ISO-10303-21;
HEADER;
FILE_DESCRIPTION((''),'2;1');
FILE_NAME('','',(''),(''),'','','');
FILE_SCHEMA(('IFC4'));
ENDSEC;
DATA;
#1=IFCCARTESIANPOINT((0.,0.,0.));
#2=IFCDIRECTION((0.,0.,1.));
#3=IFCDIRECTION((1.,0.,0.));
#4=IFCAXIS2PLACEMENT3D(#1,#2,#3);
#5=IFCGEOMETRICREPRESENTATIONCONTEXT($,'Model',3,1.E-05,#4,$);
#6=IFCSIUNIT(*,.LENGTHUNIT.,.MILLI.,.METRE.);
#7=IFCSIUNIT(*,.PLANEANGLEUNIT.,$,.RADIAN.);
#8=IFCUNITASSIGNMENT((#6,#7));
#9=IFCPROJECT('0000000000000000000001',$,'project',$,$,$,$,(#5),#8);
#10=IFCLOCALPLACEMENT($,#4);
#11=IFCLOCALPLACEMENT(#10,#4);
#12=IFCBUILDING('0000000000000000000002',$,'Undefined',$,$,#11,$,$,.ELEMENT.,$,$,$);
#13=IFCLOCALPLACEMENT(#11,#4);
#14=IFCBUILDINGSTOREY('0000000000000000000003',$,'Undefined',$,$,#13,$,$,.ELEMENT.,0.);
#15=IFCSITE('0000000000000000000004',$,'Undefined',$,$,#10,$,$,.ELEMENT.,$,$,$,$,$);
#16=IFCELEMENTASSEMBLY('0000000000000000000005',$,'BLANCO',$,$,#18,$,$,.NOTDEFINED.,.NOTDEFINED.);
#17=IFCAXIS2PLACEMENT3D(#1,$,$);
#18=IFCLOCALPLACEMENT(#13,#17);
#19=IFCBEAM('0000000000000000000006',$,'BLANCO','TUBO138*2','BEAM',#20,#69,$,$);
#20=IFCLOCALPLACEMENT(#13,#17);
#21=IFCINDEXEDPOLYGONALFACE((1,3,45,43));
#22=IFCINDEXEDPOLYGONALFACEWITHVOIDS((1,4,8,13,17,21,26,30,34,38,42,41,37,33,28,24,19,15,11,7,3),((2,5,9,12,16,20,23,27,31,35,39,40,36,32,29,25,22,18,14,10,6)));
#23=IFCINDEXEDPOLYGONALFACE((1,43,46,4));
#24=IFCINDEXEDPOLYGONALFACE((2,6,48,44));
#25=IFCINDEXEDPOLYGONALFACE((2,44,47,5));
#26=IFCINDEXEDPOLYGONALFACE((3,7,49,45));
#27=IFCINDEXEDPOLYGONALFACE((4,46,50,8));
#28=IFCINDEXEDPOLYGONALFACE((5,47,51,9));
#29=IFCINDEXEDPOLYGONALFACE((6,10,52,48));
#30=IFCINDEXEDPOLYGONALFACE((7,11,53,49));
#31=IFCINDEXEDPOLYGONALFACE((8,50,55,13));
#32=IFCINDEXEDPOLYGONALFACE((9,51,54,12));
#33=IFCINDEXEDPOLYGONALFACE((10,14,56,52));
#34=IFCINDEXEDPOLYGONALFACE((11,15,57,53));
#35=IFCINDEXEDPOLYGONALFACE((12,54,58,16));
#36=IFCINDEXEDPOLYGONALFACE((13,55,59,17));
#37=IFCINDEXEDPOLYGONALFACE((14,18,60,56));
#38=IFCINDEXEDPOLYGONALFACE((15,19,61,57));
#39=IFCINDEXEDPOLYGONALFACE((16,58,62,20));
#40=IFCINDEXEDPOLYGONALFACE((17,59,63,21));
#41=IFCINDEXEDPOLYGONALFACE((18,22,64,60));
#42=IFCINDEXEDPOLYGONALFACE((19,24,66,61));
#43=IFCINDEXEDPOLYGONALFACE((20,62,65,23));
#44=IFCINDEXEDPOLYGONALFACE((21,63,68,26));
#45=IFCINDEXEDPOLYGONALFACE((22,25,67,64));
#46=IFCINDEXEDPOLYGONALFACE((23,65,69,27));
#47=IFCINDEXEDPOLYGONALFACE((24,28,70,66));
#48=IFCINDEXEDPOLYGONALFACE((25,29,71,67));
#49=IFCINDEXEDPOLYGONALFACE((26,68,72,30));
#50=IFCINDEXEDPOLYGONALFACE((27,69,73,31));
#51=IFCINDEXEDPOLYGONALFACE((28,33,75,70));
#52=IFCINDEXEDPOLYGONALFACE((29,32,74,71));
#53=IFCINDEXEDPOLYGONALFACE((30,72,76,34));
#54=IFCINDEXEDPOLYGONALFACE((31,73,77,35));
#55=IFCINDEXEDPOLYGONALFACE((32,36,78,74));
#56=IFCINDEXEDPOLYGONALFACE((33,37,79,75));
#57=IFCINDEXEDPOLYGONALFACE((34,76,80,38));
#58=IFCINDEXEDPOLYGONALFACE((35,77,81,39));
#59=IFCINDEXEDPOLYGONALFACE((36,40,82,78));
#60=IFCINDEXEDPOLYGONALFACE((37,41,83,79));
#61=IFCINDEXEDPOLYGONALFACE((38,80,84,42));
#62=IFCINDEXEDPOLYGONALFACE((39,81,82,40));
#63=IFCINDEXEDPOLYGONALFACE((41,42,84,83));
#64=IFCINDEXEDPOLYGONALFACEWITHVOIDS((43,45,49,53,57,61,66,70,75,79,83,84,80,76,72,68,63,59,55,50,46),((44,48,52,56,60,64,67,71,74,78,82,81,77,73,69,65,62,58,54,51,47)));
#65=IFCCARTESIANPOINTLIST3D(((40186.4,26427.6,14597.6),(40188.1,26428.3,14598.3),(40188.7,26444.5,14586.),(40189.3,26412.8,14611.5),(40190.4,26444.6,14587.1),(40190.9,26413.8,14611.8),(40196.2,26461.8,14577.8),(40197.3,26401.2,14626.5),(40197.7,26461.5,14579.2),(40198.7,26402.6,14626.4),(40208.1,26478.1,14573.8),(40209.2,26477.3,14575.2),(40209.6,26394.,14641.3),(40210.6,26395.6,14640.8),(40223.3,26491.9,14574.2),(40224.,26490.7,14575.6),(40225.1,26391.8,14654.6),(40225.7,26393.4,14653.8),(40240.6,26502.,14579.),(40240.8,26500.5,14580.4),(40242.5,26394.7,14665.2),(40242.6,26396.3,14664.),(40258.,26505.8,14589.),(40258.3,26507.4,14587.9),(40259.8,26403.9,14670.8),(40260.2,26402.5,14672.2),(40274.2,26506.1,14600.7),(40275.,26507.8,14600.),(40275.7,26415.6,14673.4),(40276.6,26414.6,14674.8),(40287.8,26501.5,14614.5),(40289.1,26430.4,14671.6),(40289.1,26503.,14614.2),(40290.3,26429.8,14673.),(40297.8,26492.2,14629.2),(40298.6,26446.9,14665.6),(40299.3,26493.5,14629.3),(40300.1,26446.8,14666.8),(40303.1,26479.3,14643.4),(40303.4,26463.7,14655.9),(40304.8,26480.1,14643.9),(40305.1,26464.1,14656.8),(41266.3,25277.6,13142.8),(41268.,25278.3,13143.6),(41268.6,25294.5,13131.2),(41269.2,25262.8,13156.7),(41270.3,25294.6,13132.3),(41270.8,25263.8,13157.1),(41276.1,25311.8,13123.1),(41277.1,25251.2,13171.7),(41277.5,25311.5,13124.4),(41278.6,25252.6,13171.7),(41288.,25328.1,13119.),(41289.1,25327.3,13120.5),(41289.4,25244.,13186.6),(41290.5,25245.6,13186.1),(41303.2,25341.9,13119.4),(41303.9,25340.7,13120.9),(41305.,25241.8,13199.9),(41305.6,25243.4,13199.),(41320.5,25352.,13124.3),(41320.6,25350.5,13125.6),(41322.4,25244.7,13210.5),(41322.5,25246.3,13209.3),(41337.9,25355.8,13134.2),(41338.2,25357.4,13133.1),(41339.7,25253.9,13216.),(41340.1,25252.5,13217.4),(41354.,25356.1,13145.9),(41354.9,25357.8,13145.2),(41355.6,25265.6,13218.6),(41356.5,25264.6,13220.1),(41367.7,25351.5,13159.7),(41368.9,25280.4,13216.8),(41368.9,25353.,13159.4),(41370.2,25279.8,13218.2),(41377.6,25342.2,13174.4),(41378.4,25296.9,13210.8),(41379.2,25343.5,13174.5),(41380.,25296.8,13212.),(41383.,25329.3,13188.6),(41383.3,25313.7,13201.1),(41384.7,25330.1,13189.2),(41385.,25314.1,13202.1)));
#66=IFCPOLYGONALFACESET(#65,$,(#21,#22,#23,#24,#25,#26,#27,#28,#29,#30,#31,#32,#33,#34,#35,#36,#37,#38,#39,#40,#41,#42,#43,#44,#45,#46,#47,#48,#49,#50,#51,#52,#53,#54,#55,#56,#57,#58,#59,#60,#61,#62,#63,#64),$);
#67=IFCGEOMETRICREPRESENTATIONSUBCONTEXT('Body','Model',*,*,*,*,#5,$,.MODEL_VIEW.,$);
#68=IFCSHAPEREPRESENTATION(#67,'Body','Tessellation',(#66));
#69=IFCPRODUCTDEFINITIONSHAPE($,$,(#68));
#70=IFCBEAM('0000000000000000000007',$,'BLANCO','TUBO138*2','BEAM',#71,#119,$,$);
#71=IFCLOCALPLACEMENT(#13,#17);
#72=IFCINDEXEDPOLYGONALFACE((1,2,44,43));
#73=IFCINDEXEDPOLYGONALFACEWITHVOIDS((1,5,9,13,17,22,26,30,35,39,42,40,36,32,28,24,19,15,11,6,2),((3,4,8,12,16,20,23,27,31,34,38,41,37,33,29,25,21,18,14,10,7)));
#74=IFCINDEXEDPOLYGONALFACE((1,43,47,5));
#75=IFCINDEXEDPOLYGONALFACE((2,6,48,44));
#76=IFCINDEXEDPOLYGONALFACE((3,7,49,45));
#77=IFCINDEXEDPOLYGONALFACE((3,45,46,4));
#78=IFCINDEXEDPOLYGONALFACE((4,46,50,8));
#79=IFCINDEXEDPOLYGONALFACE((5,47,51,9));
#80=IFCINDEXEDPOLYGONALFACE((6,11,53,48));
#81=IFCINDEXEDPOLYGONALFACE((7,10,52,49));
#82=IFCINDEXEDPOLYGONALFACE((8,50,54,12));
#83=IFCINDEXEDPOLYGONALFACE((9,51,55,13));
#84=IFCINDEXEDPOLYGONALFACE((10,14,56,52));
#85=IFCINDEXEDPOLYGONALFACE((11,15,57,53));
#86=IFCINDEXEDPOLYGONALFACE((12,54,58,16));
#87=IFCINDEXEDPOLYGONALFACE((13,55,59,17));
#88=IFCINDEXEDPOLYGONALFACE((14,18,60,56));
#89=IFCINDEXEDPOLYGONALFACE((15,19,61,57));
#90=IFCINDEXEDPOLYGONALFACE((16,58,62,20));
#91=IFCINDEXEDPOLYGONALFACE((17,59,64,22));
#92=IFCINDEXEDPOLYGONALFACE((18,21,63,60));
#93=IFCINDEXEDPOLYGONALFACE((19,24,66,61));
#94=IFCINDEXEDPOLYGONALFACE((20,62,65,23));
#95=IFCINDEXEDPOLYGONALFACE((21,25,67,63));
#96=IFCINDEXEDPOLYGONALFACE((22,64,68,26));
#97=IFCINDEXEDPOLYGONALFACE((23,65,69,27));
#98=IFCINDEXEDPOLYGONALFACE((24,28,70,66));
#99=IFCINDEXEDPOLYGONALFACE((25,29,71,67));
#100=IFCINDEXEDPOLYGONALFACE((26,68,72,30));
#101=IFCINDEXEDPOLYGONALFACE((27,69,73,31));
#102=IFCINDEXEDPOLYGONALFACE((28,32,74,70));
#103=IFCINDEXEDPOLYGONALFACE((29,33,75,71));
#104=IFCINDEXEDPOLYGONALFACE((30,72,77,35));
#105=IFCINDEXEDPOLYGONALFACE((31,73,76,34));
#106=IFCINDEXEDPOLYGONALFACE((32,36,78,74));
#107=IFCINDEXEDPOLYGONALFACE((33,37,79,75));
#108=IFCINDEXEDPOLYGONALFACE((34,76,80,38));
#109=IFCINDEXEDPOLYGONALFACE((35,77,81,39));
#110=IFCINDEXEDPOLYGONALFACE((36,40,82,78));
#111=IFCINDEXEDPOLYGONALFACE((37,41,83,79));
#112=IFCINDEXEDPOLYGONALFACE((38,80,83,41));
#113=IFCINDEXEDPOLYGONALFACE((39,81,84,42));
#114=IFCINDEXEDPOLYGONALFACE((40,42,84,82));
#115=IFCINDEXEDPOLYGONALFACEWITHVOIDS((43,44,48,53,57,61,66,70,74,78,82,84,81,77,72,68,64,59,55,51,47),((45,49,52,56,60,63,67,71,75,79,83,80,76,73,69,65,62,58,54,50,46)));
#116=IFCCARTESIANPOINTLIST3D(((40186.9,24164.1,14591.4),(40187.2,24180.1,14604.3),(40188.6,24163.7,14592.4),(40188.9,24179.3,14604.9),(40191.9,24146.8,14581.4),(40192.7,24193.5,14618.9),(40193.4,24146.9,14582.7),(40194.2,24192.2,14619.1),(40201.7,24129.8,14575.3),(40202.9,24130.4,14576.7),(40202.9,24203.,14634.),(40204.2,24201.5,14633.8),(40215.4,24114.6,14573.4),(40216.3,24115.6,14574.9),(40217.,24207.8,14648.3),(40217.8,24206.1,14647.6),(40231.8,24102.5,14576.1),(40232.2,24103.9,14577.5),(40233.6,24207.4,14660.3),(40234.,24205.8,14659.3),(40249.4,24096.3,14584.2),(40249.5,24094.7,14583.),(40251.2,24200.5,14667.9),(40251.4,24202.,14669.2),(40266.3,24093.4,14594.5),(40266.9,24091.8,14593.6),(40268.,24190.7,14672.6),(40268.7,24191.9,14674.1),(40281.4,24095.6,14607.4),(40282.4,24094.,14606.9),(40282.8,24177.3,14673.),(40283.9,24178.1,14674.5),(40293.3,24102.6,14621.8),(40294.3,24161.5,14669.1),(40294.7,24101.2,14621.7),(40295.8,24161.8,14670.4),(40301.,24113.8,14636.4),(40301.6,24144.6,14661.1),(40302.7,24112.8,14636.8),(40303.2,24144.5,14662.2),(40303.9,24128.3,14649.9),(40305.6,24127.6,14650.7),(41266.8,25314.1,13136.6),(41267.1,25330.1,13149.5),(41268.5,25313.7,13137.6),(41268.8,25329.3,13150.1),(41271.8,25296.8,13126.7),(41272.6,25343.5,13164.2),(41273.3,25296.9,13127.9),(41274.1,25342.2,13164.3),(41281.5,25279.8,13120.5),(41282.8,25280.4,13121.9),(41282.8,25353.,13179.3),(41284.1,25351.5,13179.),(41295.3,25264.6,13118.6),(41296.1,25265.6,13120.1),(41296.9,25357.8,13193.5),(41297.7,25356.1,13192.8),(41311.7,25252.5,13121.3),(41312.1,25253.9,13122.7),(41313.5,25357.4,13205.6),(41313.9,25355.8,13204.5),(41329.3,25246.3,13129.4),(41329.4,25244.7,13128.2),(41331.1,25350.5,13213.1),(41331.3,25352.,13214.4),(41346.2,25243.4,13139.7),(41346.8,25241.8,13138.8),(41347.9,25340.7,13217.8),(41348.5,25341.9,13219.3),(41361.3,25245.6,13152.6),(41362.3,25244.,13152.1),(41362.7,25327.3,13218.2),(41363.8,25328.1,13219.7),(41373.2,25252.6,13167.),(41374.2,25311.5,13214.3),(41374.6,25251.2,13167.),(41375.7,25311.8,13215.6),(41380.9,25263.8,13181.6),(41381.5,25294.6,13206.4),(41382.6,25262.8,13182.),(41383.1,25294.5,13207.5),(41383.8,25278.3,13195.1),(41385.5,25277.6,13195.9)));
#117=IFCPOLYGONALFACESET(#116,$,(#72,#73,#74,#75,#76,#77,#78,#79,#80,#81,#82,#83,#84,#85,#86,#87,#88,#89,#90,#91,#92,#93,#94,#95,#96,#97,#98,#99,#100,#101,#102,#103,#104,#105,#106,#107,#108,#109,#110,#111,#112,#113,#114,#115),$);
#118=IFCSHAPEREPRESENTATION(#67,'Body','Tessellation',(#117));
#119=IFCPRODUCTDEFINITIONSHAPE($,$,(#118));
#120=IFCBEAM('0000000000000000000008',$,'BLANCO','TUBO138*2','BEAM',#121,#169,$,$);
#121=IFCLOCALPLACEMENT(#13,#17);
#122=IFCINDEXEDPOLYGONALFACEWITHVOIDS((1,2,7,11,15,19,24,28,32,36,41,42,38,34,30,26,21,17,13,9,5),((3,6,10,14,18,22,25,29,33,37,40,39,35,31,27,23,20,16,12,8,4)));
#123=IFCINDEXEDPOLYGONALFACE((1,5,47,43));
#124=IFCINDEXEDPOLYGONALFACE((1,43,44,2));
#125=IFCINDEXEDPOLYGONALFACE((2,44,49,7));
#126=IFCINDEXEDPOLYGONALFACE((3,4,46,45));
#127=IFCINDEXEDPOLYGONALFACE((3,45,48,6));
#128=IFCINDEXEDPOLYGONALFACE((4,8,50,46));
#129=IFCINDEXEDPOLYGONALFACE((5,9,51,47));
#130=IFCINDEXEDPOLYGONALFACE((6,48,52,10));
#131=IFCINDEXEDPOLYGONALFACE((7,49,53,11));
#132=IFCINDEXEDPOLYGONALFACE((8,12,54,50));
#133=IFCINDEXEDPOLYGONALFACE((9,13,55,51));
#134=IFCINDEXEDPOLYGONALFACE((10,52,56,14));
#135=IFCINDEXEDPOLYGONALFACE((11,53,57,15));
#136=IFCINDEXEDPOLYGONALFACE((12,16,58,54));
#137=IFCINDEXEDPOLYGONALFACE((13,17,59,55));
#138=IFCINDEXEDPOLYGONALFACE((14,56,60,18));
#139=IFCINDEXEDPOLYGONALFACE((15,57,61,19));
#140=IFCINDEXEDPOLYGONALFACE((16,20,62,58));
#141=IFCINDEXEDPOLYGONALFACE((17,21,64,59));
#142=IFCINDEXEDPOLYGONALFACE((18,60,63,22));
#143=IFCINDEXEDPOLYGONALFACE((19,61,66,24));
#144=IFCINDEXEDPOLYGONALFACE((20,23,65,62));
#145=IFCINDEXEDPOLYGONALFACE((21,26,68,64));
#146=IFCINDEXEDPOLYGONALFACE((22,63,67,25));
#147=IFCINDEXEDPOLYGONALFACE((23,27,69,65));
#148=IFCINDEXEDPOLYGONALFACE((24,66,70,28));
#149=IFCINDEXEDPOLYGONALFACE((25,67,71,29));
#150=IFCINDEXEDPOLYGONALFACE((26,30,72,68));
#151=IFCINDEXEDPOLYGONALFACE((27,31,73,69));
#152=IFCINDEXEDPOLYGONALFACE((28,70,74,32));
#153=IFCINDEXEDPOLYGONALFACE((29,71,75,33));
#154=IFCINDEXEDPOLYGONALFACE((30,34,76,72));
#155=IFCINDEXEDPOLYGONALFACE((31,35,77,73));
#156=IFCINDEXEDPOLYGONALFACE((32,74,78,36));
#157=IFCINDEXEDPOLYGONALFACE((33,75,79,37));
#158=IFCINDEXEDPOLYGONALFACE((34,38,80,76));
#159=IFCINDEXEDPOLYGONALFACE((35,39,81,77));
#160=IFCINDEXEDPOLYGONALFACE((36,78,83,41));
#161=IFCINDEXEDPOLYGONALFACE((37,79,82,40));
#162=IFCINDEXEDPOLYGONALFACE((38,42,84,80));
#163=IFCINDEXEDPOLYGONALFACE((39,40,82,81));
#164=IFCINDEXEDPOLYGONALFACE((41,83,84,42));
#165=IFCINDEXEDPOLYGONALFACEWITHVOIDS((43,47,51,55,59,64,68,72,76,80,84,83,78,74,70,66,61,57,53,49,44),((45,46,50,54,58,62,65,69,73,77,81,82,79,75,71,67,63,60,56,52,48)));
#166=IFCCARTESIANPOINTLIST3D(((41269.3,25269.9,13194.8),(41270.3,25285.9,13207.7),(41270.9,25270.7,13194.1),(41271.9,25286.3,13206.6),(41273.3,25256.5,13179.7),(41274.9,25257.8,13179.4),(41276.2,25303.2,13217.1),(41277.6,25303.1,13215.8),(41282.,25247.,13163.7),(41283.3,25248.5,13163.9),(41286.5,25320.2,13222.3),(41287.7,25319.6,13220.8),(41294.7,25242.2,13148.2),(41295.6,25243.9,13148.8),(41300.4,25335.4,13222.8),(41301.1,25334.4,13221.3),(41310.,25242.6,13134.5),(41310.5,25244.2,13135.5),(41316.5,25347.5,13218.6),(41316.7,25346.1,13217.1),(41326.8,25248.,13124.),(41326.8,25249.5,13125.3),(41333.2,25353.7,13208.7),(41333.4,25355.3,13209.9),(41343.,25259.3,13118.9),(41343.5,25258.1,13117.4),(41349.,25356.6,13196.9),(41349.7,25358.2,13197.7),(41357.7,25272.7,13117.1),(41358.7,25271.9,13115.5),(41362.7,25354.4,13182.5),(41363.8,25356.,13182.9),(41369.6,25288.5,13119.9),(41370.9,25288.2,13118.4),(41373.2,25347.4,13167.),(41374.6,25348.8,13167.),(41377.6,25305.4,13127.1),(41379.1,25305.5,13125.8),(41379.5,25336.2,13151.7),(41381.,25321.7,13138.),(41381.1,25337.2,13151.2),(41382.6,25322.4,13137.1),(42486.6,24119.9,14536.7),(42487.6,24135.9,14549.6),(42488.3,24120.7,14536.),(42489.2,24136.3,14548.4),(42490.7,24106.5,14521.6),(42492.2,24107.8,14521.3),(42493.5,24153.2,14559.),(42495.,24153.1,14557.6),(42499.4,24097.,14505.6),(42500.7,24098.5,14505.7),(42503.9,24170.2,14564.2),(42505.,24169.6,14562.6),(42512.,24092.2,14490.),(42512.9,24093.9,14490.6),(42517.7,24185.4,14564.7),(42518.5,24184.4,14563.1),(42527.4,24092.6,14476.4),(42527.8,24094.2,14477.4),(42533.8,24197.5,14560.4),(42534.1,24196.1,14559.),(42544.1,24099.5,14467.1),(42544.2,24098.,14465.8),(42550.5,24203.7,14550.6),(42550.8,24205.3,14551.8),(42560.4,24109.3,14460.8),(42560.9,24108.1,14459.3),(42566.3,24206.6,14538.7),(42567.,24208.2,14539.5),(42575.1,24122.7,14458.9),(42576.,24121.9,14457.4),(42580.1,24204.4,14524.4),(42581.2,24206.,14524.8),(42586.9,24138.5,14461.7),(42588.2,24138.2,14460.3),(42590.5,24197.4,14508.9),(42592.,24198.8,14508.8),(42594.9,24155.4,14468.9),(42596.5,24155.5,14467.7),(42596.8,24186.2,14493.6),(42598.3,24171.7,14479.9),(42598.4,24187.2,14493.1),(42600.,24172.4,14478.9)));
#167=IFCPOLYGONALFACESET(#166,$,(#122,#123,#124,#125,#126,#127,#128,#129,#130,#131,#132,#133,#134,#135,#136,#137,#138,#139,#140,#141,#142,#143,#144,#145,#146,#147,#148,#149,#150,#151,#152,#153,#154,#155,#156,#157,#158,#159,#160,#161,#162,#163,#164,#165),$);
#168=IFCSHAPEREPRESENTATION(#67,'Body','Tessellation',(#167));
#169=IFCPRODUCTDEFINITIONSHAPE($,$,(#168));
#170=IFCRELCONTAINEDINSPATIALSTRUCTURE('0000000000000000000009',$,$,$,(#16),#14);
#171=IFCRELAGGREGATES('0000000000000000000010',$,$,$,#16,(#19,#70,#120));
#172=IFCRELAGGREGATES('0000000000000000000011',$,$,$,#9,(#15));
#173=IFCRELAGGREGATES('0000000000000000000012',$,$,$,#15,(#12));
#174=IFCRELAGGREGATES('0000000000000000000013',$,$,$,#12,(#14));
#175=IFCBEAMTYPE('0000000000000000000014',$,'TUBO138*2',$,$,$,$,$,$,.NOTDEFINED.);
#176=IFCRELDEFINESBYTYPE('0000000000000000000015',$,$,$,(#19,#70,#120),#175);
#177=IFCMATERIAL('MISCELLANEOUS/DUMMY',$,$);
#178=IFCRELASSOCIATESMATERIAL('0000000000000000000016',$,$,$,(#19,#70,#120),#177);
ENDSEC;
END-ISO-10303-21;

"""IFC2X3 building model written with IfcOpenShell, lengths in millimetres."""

from ifc_helpers import new_model, si_unit, frame, origin_with_axes, origin_2d_with_axis, place, context, subcontext, project, spatial, hollow_circle, extrude, material, type_object, element, aggregate, save


model = new_model("IFC2X3")

# Units and contexts
model_context = context("Model", 3, precision=1e-05, world=origin_with_axes())
body_context = subcontext(model_context, "Body", "Model", "MODEL_VIEW")
ifc_project = project(units=[si_unit("LENGTHUNIT", "METRE", prefix="MILLI"), si_unit("PLANEANGLEUNIT", "RADIAN")], contexts=[model_context])

# Site, building, storey
site_placement = place(None, origin_with_axes())
site = spatial("IfcSite", under=ifc_project, at=site_placement, Name="Undefined", CompositionType="ELEMENT")
building_placement = place(site_placement, origin_with_axes())
building = spatial("IfcBuilding", under=site, at=building_placement, Name="Undefined", CompositionType="ELEMENT")
storey_placement = place(building_placement, origin_with_axes())
storey = spatial("IfcBuildingStorey", under=building, at=storey_placement, Name="Undefined", CompositionType="ELEMENT", Elevation=0.0)

# Element assembly, beams
assembly_placement = place(storey_placement, origin_with_axes())
assembly = element("IfcElementAssembly", 1, at=assembly_placement, inside=storey, Name="BLANCO", AssemblyPlace="NOTDEFINED", PredefinedType="NOTDEFINED")
ifc_material = material(Name="MISCELLANEOUS/DUMMY")
beam_type = type_object("IfcBeamType", Name="TUBO138*2", PredefinedType="NOTDEFINED")
beam_1_placement = place(assembly_placement, frame((41325.9, 25300.0, 13169.4), z_axis=(-0.497966, 0.461316, -0.734314), x_axis=(-0.503224, 0.535899, 0.677922)))
beam_1 = element("IfcBeam", 2, at=beam_1_placement, type_object=beam_type, material=ifc_material, Name="BLANCO", Description="TUBO138*2", ObjectType="BEAM", context=body_context, shape_type="SweptSolid", body=[
    extrude(hollow_circle(Radius=69.0, WallThickness=2.0, at=origin_2d_with_axis()), frame((2145.9, 0.0, 0.0), z_axis=(-1.0, 0.0, 0.0), x_axis=(0.0, -1.0, 0.0)), (0.0, 0.0, 1.0), 2145.9),
])
beam_2_placement = place(assembly_placement, frame((41325.9, 25300.0, 13169.4), z_axis=(-0.497966, -0.461316, -0.734314), x_axis=(-0.503224, -0.535899, 0.677922)))
beam_2 = element("IfcBeam", 3, at=beam_2_placement, type_object=beam_type, material=ifc_material, Name="BLANCO", Description="TUBO138*2", ObjectType="BEAM", context=body_context, shape_type="SweptSolid", body=[
    extrude(hollow_circle(Radius=69.0, WallThickness=2.0, at=origin_2d_with_axis()), frame((2145.9, 0.0, 0.0), z_axis=(-1.0, 0.0, 0.0), x_axis=(0.0, -1.0, 0.0)), (0.0, 0.0, 1.0), 2145.9),
])
beam_3_placement = place(assembly_placement, frame((41325.9, 25300.0, 13169.4), z_axis=(0.423552, -0.461316, -0.77961), x_axis=(0.567282, -0.535899, 0.625303)))
beam_3 = element("IfcBeam", 4, at=beam_3_placement, type_object=beam_type, material=ifc_material, Name="BLANCO", Description="TUBO138*2", ObjectType="BEAM", context=body_context, shape_type="SweptSolid", body=[
    extrude(hollow_circle(Radius=69.0, WallThickness=2.0, at=origin_2d_with_axis()), frame((2145.9, 0.0, 0.0), z_axis=(-1.0, 0.0, 0.0), x_axis=(0.0, -1.0, 0.0)), (0.0, 0.0, 1.0), 2145.9),
])
aggregate(assembly, [beam_1, beam_2, beam_3])

save(model, "model.ifc")
